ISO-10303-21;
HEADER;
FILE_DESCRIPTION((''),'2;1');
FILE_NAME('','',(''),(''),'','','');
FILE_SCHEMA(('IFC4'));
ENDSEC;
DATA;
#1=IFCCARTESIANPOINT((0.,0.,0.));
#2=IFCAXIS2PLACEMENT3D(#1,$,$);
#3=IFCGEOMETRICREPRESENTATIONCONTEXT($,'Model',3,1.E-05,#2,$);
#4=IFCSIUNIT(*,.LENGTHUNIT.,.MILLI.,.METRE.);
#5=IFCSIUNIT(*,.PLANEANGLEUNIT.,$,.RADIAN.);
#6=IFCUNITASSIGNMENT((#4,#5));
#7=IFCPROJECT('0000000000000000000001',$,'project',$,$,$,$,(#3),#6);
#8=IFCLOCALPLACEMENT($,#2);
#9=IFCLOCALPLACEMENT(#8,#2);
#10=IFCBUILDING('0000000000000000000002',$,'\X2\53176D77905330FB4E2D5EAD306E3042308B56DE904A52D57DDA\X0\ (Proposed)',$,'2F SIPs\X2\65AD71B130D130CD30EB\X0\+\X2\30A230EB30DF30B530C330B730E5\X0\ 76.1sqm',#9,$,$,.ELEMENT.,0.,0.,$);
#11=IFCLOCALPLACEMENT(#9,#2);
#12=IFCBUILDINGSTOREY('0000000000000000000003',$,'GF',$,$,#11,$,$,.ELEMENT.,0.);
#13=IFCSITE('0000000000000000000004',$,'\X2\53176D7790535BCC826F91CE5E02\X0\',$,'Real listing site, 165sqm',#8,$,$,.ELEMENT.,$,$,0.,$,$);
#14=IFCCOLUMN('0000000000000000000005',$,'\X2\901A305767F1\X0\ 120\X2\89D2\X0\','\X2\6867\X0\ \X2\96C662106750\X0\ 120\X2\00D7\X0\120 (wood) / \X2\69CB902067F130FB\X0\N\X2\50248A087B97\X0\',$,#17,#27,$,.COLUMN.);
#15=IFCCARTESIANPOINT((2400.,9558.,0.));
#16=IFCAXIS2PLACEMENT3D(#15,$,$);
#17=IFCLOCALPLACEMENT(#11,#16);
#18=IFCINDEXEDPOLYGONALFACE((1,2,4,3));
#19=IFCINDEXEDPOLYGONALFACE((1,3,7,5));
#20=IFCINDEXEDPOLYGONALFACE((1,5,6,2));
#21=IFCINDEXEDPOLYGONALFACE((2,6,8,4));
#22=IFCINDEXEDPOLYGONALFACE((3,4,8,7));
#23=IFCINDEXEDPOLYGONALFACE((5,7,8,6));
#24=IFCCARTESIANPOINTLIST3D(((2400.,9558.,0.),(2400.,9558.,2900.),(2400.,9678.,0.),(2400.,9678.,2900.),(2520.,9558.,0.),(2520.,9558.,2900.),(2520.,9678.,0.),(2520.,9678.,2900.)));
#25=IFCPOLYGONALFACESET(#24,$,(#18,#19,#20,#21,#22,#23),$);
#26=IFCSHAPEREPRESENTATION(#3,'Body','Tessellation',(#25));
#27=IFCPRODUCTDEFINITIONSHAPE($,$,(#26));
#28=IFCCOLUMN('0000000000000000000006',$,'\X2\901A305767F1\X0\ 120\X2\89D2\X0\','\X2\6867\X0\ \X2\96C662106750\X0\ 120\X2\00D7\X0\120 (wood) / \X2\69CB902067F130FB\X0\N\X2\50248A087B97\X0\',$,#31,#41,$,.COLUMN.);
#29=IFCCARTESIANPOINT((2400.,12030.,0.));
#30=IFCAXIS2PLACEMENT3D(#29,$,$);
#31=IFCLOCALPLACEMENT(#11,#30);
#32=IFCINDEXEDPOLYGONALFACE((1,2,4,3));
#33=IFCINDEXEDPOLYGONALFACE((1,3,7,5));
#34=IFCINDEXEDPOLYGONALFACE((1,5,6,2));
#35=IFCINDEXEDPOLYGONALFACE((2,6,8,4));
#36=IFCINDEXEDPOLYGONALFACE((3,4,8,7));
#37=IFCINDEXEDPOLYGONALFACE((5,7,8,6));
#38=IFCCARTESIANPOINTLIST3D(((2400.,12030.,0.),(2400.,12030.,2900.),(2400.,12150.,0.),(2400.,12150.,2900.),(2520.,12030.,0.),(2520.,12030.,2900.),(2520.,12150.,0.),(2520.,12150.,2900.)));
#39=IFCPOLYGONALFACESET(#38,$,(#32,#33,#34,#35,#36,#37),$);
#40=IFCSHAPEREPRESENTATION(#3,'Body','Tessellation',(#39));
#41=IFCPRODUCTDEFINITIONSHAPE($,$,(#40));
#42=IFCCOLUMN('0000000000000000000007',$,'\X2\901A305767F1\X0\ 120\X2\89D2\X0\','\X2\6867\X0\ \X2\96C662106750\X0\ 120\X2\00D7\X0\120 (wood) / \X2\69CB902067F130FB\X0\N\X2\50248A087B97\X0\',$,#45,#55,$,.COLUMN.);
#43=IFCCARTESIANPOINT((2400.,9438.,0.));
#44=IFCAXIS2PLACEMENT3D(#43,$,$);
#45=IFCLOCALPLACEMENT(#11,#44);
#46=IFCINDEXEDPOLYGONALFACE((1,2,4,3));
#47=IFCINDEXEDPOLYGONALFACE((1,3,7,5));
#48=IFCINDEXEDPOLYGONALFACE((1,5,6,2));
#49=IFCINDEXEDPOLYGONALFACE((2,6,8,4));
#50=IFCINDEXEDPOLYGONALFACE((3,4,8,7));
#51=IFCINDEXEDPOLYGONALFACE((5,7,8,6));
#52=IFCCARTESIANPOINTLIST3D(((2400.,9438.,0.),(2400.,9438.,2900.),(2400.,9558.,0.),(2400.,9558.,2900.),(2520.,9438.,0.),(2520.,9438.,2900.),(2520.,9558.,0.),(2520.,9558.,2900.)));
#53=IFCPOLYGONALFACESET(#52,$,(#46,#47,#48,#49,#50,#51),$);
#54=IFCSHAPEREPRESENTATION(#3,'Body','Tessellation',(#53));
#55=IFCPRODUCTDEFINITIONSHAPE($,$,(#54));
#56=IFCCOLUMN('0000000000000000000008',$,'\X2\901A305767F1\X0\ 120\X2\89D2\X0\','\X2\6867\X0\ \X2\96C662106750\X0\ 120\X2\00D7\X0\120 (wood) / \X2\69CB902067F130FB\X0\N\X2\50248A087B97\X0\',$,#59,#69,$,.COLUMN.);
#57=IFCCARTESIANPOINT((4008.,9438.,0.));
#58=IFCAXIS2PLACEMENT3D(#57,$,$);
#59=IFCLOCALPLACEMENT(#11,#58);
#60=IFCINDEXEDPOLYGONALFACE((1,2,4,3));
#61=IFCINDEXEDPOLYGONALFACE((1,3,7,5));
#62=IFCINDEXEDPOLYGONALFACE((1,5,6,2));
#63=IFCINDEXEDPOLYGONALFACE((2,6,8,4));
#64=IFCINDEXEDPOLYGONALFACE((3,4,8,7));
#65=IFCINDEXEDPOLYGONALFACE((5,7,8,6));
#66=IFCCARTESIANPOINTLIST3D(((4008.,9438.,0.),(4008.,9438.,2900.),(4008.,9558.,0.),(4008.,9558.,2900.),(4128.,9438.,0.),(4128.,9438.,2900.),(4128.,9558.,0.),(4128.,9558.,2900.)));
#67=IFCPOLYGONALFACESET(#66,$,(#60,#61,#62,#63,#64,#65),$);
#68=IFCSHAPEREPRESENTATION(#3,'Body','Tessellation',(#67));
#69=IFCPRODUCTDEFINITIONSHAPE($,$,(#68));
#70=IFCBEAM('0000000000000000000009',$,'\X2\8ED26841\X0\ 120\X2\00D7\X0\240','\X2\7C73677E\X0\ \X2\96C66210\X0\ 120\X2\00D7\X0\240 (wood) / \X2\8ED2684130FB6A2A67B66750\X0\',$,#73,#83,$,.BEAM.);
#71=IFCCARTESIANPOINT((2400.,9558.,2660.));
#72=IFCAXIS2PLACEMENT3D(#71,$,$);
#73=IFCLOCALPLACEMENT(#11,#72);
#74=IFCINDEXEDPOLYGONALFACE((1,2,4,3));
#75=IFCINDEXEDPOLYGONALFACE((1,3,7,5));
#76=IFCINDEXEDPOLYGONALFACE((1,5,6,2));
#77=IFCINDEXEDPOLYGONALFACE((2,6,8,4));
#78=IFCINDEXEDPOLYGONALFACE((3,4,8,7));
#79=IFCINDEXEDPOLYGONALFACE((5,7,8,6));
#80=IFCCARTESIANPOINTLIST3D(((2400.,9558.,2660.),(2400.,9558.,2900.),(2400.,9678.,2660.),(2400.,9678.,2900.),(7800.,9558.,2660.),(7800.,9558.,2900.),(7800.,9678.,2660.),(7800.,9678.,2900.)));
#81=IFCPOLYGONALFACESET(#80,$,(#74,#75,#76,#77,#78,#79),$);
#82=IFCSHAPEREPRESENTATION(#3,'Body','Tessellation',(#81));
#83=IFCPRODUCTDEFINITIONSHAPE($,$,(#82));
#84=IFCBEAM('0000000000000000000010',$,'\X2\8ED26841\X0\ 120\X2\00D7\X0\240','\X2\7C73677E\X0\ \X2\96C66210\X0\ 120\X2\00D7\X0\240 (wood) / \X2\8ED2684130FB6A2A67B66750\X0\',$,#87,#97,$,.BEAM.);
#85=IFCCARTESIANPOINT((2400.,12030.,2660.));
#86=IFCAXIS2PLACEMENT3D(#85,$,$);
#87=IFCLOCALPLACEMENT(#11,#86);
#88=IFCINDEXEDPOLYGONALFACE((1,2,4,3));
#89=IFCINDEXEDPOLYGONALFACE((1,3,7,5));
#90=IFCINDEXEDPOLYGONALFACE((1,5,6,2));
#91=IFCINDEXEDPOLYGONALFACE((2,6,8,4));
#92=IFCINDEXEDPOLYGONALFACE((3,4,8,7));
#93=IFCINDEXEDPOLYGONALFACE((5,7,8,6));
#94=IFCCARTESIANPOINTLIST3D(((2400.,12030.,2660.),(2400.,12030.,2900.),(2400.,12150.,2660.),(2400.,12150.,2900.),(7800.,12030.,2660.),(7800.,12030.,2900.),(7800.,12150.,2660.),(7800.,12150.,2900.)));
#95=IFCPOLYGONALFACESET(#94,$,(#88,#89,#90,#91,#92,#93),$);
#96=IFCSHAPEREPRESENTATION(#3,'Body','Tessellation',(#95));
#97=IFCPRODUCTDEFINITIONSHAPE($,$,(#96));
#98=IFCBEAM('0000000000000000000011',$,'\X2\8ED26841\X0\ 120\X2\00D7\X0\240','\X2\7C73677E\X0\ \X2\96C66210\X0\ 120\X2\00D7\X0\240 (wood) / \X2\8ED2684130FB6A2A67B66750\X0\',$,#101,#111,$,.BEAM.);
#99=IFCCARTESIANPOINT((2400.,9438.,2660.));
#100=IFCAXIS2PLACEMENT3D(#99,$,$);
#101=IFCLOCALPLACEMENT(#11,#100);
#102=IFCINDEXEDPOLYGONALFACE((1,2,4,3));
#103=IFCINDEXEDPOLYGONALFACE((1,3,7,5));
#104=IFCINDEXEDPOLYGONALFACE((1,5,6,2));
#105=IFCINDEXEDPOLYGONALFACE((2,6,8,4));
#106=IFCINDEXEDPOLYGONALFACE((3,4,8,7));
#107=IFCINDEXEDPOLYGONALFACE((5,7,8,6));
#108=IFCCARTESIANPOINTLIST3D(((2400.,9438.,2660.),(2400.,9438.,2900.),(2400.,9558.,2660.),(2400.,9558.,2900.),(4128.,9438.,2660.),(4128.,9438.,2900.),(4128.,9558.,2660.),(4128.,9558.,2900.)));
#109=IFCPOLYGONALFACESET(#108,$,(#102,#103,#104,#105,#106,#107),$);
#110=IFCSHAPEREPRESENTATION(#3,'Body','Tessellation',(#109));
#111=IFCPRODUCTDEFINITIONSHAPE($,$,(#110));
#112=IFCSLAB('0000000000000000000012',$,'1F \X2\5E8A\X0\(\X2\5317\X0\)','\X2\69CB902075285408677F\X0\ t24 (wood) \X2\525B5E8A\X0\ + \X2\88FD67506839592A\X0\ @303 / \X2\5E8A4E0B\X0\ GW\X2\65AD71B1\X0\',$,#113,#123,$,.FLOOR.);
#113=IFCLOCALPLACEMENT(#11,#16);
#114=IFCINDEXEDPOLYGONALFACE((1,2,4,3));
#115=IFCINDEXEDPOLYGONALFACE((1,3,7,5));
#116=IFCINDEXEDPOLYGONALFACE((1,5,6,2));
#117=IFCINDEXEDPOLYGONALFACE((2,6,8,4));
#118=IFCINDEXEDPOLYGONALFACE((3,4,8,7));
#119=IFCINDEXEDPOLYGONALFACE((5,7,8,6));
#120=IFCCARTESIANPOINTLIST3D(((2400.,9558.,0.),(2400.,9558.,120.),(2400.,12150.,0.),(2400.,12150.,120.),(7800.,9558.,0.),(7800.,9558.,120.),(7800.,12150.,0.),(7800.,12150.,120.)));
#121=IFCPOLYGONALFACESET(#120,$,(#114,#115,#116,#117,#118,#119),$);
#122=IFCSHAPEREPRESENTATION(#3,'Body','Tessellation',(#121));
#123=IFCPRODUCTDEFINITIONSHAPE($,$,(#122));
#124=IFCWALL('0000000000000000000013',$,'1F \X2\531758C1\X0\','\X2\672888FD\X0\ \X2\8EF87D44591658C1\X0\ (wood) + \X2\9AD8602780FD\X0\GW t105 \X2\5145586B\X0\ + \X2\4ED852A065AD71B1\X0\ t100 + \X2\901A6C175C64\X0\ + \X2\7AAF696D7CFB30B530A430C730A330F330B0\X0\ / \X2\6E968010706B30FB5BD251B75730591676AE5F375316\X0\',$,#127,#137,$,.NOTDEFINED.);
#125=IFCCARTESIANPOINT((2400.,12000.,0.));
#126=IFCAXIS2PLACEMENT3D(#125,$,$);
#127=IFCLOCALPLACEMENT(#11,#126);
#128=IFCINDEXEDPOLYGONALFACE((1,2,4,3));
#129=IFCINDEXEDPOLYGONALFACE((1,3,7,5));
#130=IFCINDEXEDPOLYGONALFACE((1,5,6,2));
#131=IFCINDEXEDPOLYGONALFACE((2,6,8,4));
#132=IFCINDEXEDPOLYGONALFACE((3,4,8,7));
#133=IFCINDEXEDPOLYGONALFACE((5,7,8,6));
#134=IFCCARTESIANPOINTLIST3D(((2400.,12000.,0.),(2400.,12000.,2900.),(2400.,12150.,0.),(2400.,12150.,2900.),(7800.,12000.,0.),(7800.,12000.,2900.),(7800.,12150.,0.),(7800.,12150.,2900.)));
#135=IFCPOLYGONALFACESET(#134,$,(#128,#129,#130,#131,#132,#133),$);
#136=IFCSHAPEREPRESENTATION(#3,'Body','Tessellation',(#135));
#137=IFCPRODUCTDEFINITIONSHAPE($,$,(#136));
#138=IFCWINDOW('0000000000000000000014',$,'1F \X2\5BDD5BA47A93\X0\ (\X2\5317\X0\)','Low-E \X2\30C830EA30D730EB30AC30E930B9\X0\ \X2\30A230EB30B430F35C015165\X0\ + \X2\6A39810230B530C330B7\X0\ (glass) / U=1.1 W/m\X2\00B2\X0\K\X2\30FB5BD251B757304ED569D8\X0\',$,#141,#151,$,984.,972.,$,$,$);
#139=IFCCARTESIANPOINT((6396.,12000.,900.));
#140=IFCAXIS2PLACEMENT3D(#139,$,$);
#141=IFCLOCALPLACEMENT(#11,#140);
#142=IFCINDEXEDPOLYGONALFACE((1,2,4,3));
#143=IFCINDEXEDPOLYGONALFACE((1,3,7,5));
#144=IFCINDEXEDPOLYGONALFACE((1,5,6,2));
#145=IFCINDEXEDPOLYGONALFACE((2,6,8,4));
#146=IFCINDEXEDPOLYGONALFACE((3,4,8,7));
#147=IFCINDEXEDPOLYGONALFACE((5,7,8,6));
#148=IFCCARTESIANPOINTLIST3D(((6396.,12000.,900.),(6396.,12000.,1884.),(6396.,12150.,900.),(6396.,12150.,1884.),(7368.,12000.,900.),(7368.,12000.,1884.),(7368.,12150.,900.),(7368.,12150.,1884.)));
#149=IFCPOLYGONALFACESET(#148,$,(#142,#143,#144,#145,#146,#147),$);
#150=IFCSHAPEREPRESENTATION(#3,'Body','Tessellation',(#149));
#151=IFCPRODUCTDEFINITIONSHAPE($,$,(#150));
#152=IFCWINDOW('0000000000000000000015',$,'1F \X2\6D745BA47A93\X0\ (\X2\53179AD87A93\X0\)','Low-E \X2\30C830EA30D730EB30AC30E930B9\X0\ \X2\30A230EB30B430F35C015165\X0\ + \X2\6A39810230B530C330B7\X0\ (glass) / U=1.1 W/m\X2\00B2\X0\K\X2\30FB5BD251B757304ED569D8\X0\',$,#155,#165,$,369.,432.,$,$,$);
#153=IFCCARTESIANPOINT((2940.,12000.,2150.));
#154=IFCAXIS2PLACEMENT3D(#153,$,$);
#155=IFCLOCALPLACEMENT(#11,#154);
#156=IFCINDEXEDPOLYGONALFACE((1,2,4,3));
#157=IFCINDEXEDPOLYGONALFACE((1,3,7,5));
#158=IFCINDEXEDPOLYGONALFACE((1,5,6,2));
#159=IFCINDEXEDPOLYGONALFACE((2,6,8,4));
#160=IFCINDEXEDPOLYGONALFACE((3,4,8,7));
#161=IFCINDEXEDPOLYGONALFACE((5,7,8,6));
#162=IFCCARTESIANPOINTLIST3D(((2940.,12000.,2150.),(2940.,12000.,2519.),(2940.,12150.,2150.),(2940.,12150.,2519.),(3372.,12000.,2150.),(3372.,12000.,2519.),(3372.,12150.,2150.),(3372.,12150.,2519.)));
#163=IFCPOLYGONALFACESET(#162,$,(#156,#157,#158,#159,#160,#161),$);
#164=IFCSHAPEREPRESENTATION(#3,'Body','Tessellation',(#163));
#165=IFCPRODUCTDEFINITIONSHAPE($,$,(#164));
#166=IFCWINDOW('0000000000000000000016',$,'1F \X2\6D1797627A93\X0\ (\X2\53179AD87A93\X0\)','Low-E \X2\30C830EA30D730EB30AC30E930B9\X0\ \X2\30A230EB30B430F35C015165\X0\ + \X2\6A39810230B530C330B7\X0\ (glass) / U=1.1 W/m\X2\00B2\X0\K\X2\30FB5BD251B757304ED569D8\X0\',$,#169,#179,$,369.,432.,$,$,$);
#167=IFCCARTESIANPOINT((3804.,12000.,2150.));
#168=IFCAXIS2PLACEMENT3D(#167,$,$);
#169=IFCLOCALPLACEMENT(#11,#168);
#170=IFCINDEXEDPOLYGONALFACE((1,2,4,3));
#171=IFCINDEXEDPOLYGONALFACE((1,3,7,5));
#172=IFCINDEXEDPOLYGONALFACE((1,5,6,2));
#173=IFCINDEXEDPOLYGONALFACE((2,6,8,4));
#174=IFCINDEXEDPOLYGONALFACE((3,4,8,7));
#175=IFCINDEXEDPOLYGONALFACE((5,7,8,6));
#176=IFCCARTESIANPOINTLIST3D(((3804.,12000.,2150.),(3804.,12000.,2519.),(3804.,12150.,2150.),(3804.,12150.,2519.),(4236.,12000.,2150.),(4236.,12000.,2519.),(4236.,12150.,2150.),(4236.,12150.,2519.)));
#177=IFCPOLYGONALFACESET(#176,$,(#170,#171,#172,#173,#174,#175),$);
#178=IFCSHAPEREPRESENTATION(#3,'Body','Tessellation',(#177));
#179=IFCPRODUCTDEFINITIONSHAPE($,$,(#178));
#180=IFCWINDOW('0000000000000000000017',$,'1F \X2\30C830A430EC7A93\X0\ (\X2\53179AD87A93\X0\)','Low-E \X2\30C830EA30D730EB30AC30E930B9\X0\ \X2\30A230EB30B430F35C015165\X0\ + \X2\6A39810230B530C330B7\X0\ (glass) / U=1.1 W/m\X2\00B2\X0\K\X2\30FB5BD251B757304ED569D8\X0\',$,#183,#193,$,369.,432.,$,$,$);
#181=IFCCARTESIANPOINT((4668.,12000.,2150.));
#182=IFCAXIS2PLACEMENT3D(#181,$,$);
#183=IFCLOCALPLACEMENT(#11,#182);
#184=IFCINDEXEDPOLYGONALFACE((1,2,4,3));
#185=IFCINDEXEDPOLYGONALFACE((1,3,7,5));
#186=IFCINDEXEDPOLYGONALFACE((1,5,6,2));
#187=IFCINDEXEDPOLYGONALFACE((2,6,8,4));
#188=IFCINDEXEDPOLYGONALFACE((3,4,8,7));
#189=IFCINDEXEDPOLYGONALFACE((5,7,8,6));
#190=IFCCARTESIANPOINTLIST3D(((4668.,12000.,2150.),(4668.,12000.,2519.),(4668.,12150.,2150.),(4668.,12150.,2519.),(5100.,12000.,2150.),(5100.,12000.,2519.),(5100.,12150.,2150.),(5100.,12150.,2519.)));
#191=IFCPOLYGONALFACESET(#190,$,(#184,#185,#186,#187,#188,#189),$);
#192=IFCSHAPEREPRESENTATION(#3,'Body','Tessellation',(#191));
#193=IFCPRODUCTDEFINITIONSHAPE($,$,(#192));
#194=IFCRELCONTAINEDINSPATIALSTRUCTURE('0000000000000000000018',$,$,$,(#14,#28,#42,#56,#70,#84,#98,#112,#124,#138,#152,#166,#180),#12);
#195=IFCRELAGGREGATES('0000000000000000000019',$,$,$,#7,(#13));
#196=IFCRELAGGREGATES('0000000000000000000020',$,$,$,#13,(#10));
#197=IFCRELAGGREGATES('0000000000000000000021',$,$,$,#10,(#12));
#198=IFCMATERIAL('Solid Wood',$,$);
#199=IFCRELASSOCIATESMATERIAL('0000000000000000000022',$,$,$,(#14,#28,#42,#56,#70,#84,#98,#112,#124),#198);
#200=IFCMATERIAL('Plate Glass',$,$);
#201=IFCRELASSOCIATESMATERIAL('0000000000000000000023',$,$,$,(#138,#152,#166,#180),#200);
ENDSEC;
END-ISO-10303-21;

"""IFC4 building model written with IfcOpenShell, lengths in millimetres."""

from ifc_helpers import new_model, si_unit, frame, frame_2d, origin, place, context, project, spatial, rectangle, extrude, material, element, fill, save


model = new_model("IFC4")

# Units and contexts
model_context = context("Model", 3, precision=1e-05, world=origin())
ifc_project = project(units=[si_unit("LENGTHUNIT", "METRE", prefix="MILLI"), si_unit("PLANEANGLEUNIT", "RADIAN")], contexts=[model_context])

# Site, building, storey
site_placement = place(None, origin())
site = spatial("IfcSite", under=ifc_project, at=site_placement, Name="北海道富良野市", ObjectType="Real listing site, 165sqm", CompositionType="ELEMENT", RefElevation=0.0)
building_placement = place(site_placement, origin())
building = spatial("IfcBuilding", under=site, at=building_placement, Name="北海道・中庭のある回遊動線 (Proposed)", ObjectType="2F SIPs断熱パネル+アルミサッシュ 76.1sqm", CompositionType="ELEMENT", ElevationOfRefHeight=0.0, ElevationOfTerrain=0.0)
storey_placement = place(building_placement, origin())
storey = spatial("IfcBuildingStorey", under=building, at=storey_placement, Name="GF", CompositionType="ELEMENT", Elevation=0.0)

# Columns
ifc_material_1 = material(Name="Solid Wood")
column_1_placement = place(storey_placement, frame((2400.0, 9558.0, 0.0)))
element("IfcColumn", 1, at=column_1_placement, inside=storey, material=ifc_material_1, Name="通し柱 120角", Description="桧 集成材 120×120 (wood) / 構造柱・N値計算", PredefinedType="COLUMN", context=model_context, shape_type="SweptSolid", body=[
    extrude(rectangle(XDim=120.0, YDim=120.0, at=frame_2d((60.0, 60.0))), frame((2400.0, 9558.0, 0.0)), (0.0, 0.0, 1.0), 2900.0),
])
column_2_placement = place(storey_placement, frame((2400.0, 12030.0, 0.0)))
element("IfcColumn", 2, at=column_2_placement, inside=storey, material=ifc_material_1, Name="通し柱 120角", Description="桧 集成材 120×120 (wood) / 構造柱・N値計算", PredefinedType="COLUMN", context=model_context, shape_type="SweptSolid", body=[
    extrude(rectangle(XDim=120.0, YDim=120.0, at=frame_2d((60.0, 60.0))), frame((2400.0, 12030.0, 0.0)), (0.0, 0.0, 1.0), 2900.0),
])
column_3_placement = place(storey_placement, frame((2400.0, 9438.0, 0.0)))
element("IfcColumn", 3, at=column_3_placement, inside=storey, material=ifc_material_1, Name="通し柱 120角", Description="桧 集成材 120×120 (wood) / 構造柱・N値計算", PredefinedType="COLUMN", context=model_context, shape_type="SweptSolid", body=[
    extrude(rectangle(XDim=120.0, YDim=120.0, at=frame_2d((60.0, 60.0))), frame((2400.0, 9438.0, 0.0)), (0.0, 0.0, 1.0), 2900.0),
])
column_4_placement = place(storey_placement, frame((4008.0, 9438.0, 0.0)))
element("IfcColumn", 4, at=column_4_placement, inside=storey, material=ifc_material_1, Name="通し柱 120角", Description="桧 集成材 120×120 (wood) / 構造柱・N値計算", PredefinedType="COLUMN", context=model_context, shape_type="SweptSolid", body=[
    extrude(rectangle(XDim=120.0, YDim=120.0, at=frame_2d((60.0, 60.0))), frame((4008.0, 9438.0, 0.0)), (0.0, 0.0, 1.0), 2900.0),
])

# Beams
beam_1_placement = place(storey_placement, frame((2400.0, 9558.0, 2660.0)))
element("IfcBeam", 5, at=beam_1_placement, inside=storey, material=ifc_material_1, Name="軒桁 120×240", Description="米松 集成 120×240 (wood) / 軒桁・横架材", PredefinedType="BEAM", context=model_context, shape_type="SweptSolid", body=[
    extrude(rectangle(XDim=5400.0, YDim=120.0, at=frame_2d((2700.0, 60.0))), frame((2400.0, 9558.0, 2660.0)), (0.0, 0.0, 1.0), 240.0),
])
beam_2_placement = place(storey_placement, frame((2400.0, 12030.0, 2660.0)))
element("IfcBeam", 6, at=beam_2_placement, inside=storey, material=ifc_material_1, Name="軒桁 120×240", Description="米松 集成 120×240 (wood) / 軒桁・横架材", PredefinedType="BEAM", context=model_context, shape_type="SweptSolid", body=[
    extrude(rectangle(XDim=5400.0, YDim=120.0, at=frame_2d((2700.0, 60.0))), frame((2400.0, 12030.0, 2660.0)), (0.0, 0.0, 1.0), 240.0),
])
beam_3_placement = place(storey_placement, frame((2400.0, 9438.0, 2660.0)))
element("IfcBeam", 7, at=beam_3_placement, inside=storey, material=ifc_material_1, Name="軒桁 120×240", Description="米松 集成 120×240 (wood) / 軒桁・横架材", PredefinedType="BEAM", context=model_context, shape_type="SweptSolid", body=[
    extrude(rectangle(XDim=1728.0, YDim=120.0, at=frame_2d((864.0, 60.0))), frame((2400.0, 9438.0, 2660.0)), (0.0, 0.0, 1.0), 240.0),
])

# Slab
slab_placement = place(storey_placement, frame((2400.0, 9558.0, 0.0)))
element("IfcSlab", 8, at=slab_placement, inside=storey, material=ifc_material_1, Name="1F 床(北)", Description="構造用合板 t24 (wood) 剛床 + 製材根太 @303 / 床下 GW断熱", PredefinedType="FLOOR", context=model_context, shape_type="SweptSolid", body=[
    extrude(rectangle(XDim=5400.0, YDim=2592.0, at=frame_2d((2700.0, 1296.0))), frame((2400.0, 9558.0, 0.0)), (0.0, 0.0, 1.0), 120.0),
])

# Wall, openings, windows
wall_1_placement = place(storey_placement, frame((2400.0, 12000.0, 0.0)))
wall_1 = element("IfcWall", 9, at=wall_1_placement, inside=storey, material=ifc_material_1, Name="1F 北壁", Description="木製 軸組外壁 (wood) + 高性能GW t105 充填 + 付加断熱 t100 + 通気層 + 窯業系サイディング / 準耐火・寒冷地外皮強化", PredefinedType="NOTDEFINED", context=model_context, shape_type="SweptSolid", body=[
    extrude(rectangle(XDim=5400.0, YDim=150.0, at=frame_2d((2700.0, 75.0))), frame((2400.0, 12000.0, 0.0)), (0.0, 0.0, 1.0), 2900.0),
])
opening_1_placement = place(storey_placement, frame((6396.0, 12000.0, 900.0)))
opening_1 = element("IfcOpeningElement", 10, at=opening_1_placement, cuts=wall_1, PredefinedType="NOTDEFINED", context=model_context, shape_type="SweptSolid", body=[
    extrude(rectangle(XDim=972.0, YDim=150.0, at=frame_2d((486.0, 75.0))), frame((6396.0, 12000.0, 900.0)), (0.0, 0.0, 1.0), 984.0),
])
opening_2_placement = place(storey_placement, frame((2940.0, 12000.0, 2150.0)))
opening_2 = element("IfcOpeningElement", 11, at=opening_2_placement, cuts=wall_1, PredefinedType="NOTDEFINED", context=model_context, shape_type="SweptSolid", body=[
    extrude(rectangle(XDim=432.0, YDim=150.0, at=frame_2d((216.0, 75.0))), frame((2940.0, 12000.0, 2150.0)), (0.0, 0.0, 1.0), 369.0),
])
opening_3_placement = place(storey_placement, frame((3804.0, 12000.0, 2150.0)))
opening_3 = element("IfcOpeningElement", 12, at=opening_3_placement, cuts=wall_1, PredefinedType="NOTDEFINED", context=model_context, shape_type="SweptSolid", body=[
    extrude(rectangle(XDim=432.0, YDim=150.0, at=frame_2d((216.0, 75.0))), frame((3804.0, 12000.0, 2150.0)), (0.0, 0.0, 1.0), 369.0),
])
opening_4_placement = place(storey_placement, frame((4668.0, 12000.0, 2150.0)))
opening_4 = element("IfcOpeningElement", 13, at=opening_4_placement, cuts=wall_1, PredefinedType="NOTDEFINED", context=model_context, shape_type="SweptSolid", body=[
    extrude(rectangle(XDim=432.0, YDim=150.0, at=frame_2d((216.0, 75.0))), frame((4668.0, 12000.0, 2150.0)), (0.0, 0.0, 1.0), 369.0),
])
ifc_material_2 = material(Name="Plate Glass")
window_1_placement = place(storey_placement, frame((6396.0, 12000.0, 900.0)))
window_1 = element("IfcWindow", 14, at=window_1_placement, inside=storey, material=ifc_material_2, Name="1F 寝室窓 (北)", Description="Low-E トリプルガラス アルゴン封入 + 樹脂サッシ (glass) / U=1.1 W/m²K・寒冷地仕様", OverallHeight=984.0, OverallWidth=972.0, context=model_context, shape_type="SweptSolid", body=[
    extrude(rectangle(XDim=972.0, YDim=150.0, at=frame_2d((486.0, 75.0))), frame((6396.0, 12000.0, 900.0)), (0.0, 0.0, 1.0), 984.0),
])
fill(opening_1, window_1)
window_2_placement = place(storey_placement, frame((2940.0, 12000.0, 2150.0)))
window_2 = element("IfcWindow", 15, at=window_2_placement, inside=storey, material=ifc_material_2, Name="1F 浴室窓 (北高窓)", Description="Low-E トリプルガラス アルゴン封入 + 樹脂サッシ (glass) / U=1.1 W/m²K・寒冷地仕様", OverallHeight=369.0, OverallWidth=432.0, context=model_context, shape_type="SweptSolid", body=[
    extrude(rectangle(XDim=432.0, YDim=150.0, at=frame_2d((216.0, 75.0))), frame((2940.0, 12000.0, 2150.0)), (0.0, 0.0, 1.0), 369.0),
])
fill(opening_2, window_2)
window_3_placement = place(storey_placement, frame((3804.0, 12000.0, 2150.0)))
window_3 = element("IfcWindow", 16, at=window_3_placement, inside=storey, material=ifc_material_2, Name="1F 洗面窓 (北高窓)", Description="Low-E トリプルガラス アルゴン封入 + 樹脂サッシ (glass) / U=1.1 W/m²K・寒冷地仕様", OverallHeight=369.0, OverallWidth=432.0, context=model_context, shape_type="SweptSolid", body=[
    extrude(rectangle(XDim=432.0, YDim=150.0, at=frame_2d((216.0, 75.0))), frame((3804.0, 12000.0, 2150.0)), (0.0, 0.0, 1.0), 369.0),
])
fill(opening_3, window_3)
window_4_placement = place(storey_placement, frame((4668.0, 12000.0, 2150.0)))
window_4 = element("IfcWindow", 17, at=window_4_placement, inside=storey, material=ifc_material_2, Name="1F トイレ窓 (北高窓)", Description="Low-E トリプルガラス アルゴン封入 + 樹脂サッシ (glass) / U=1.1 W/m²K・寒冷地仕様", OverallHeight=369.0, OverallWidth=432.0, context=model_context, shape_type="SweptSolid", body=[
    extrude(rectangle(XDim=432.0, YDim=150.0, at=frame_2d((216.0, 75.0))), frame((4668.0, 12000.0, 2150.0)), (0.0, 0.0, 1.0), 369.0),
])
fill(opening_4, window_4)

save(model, "model.ifc")
